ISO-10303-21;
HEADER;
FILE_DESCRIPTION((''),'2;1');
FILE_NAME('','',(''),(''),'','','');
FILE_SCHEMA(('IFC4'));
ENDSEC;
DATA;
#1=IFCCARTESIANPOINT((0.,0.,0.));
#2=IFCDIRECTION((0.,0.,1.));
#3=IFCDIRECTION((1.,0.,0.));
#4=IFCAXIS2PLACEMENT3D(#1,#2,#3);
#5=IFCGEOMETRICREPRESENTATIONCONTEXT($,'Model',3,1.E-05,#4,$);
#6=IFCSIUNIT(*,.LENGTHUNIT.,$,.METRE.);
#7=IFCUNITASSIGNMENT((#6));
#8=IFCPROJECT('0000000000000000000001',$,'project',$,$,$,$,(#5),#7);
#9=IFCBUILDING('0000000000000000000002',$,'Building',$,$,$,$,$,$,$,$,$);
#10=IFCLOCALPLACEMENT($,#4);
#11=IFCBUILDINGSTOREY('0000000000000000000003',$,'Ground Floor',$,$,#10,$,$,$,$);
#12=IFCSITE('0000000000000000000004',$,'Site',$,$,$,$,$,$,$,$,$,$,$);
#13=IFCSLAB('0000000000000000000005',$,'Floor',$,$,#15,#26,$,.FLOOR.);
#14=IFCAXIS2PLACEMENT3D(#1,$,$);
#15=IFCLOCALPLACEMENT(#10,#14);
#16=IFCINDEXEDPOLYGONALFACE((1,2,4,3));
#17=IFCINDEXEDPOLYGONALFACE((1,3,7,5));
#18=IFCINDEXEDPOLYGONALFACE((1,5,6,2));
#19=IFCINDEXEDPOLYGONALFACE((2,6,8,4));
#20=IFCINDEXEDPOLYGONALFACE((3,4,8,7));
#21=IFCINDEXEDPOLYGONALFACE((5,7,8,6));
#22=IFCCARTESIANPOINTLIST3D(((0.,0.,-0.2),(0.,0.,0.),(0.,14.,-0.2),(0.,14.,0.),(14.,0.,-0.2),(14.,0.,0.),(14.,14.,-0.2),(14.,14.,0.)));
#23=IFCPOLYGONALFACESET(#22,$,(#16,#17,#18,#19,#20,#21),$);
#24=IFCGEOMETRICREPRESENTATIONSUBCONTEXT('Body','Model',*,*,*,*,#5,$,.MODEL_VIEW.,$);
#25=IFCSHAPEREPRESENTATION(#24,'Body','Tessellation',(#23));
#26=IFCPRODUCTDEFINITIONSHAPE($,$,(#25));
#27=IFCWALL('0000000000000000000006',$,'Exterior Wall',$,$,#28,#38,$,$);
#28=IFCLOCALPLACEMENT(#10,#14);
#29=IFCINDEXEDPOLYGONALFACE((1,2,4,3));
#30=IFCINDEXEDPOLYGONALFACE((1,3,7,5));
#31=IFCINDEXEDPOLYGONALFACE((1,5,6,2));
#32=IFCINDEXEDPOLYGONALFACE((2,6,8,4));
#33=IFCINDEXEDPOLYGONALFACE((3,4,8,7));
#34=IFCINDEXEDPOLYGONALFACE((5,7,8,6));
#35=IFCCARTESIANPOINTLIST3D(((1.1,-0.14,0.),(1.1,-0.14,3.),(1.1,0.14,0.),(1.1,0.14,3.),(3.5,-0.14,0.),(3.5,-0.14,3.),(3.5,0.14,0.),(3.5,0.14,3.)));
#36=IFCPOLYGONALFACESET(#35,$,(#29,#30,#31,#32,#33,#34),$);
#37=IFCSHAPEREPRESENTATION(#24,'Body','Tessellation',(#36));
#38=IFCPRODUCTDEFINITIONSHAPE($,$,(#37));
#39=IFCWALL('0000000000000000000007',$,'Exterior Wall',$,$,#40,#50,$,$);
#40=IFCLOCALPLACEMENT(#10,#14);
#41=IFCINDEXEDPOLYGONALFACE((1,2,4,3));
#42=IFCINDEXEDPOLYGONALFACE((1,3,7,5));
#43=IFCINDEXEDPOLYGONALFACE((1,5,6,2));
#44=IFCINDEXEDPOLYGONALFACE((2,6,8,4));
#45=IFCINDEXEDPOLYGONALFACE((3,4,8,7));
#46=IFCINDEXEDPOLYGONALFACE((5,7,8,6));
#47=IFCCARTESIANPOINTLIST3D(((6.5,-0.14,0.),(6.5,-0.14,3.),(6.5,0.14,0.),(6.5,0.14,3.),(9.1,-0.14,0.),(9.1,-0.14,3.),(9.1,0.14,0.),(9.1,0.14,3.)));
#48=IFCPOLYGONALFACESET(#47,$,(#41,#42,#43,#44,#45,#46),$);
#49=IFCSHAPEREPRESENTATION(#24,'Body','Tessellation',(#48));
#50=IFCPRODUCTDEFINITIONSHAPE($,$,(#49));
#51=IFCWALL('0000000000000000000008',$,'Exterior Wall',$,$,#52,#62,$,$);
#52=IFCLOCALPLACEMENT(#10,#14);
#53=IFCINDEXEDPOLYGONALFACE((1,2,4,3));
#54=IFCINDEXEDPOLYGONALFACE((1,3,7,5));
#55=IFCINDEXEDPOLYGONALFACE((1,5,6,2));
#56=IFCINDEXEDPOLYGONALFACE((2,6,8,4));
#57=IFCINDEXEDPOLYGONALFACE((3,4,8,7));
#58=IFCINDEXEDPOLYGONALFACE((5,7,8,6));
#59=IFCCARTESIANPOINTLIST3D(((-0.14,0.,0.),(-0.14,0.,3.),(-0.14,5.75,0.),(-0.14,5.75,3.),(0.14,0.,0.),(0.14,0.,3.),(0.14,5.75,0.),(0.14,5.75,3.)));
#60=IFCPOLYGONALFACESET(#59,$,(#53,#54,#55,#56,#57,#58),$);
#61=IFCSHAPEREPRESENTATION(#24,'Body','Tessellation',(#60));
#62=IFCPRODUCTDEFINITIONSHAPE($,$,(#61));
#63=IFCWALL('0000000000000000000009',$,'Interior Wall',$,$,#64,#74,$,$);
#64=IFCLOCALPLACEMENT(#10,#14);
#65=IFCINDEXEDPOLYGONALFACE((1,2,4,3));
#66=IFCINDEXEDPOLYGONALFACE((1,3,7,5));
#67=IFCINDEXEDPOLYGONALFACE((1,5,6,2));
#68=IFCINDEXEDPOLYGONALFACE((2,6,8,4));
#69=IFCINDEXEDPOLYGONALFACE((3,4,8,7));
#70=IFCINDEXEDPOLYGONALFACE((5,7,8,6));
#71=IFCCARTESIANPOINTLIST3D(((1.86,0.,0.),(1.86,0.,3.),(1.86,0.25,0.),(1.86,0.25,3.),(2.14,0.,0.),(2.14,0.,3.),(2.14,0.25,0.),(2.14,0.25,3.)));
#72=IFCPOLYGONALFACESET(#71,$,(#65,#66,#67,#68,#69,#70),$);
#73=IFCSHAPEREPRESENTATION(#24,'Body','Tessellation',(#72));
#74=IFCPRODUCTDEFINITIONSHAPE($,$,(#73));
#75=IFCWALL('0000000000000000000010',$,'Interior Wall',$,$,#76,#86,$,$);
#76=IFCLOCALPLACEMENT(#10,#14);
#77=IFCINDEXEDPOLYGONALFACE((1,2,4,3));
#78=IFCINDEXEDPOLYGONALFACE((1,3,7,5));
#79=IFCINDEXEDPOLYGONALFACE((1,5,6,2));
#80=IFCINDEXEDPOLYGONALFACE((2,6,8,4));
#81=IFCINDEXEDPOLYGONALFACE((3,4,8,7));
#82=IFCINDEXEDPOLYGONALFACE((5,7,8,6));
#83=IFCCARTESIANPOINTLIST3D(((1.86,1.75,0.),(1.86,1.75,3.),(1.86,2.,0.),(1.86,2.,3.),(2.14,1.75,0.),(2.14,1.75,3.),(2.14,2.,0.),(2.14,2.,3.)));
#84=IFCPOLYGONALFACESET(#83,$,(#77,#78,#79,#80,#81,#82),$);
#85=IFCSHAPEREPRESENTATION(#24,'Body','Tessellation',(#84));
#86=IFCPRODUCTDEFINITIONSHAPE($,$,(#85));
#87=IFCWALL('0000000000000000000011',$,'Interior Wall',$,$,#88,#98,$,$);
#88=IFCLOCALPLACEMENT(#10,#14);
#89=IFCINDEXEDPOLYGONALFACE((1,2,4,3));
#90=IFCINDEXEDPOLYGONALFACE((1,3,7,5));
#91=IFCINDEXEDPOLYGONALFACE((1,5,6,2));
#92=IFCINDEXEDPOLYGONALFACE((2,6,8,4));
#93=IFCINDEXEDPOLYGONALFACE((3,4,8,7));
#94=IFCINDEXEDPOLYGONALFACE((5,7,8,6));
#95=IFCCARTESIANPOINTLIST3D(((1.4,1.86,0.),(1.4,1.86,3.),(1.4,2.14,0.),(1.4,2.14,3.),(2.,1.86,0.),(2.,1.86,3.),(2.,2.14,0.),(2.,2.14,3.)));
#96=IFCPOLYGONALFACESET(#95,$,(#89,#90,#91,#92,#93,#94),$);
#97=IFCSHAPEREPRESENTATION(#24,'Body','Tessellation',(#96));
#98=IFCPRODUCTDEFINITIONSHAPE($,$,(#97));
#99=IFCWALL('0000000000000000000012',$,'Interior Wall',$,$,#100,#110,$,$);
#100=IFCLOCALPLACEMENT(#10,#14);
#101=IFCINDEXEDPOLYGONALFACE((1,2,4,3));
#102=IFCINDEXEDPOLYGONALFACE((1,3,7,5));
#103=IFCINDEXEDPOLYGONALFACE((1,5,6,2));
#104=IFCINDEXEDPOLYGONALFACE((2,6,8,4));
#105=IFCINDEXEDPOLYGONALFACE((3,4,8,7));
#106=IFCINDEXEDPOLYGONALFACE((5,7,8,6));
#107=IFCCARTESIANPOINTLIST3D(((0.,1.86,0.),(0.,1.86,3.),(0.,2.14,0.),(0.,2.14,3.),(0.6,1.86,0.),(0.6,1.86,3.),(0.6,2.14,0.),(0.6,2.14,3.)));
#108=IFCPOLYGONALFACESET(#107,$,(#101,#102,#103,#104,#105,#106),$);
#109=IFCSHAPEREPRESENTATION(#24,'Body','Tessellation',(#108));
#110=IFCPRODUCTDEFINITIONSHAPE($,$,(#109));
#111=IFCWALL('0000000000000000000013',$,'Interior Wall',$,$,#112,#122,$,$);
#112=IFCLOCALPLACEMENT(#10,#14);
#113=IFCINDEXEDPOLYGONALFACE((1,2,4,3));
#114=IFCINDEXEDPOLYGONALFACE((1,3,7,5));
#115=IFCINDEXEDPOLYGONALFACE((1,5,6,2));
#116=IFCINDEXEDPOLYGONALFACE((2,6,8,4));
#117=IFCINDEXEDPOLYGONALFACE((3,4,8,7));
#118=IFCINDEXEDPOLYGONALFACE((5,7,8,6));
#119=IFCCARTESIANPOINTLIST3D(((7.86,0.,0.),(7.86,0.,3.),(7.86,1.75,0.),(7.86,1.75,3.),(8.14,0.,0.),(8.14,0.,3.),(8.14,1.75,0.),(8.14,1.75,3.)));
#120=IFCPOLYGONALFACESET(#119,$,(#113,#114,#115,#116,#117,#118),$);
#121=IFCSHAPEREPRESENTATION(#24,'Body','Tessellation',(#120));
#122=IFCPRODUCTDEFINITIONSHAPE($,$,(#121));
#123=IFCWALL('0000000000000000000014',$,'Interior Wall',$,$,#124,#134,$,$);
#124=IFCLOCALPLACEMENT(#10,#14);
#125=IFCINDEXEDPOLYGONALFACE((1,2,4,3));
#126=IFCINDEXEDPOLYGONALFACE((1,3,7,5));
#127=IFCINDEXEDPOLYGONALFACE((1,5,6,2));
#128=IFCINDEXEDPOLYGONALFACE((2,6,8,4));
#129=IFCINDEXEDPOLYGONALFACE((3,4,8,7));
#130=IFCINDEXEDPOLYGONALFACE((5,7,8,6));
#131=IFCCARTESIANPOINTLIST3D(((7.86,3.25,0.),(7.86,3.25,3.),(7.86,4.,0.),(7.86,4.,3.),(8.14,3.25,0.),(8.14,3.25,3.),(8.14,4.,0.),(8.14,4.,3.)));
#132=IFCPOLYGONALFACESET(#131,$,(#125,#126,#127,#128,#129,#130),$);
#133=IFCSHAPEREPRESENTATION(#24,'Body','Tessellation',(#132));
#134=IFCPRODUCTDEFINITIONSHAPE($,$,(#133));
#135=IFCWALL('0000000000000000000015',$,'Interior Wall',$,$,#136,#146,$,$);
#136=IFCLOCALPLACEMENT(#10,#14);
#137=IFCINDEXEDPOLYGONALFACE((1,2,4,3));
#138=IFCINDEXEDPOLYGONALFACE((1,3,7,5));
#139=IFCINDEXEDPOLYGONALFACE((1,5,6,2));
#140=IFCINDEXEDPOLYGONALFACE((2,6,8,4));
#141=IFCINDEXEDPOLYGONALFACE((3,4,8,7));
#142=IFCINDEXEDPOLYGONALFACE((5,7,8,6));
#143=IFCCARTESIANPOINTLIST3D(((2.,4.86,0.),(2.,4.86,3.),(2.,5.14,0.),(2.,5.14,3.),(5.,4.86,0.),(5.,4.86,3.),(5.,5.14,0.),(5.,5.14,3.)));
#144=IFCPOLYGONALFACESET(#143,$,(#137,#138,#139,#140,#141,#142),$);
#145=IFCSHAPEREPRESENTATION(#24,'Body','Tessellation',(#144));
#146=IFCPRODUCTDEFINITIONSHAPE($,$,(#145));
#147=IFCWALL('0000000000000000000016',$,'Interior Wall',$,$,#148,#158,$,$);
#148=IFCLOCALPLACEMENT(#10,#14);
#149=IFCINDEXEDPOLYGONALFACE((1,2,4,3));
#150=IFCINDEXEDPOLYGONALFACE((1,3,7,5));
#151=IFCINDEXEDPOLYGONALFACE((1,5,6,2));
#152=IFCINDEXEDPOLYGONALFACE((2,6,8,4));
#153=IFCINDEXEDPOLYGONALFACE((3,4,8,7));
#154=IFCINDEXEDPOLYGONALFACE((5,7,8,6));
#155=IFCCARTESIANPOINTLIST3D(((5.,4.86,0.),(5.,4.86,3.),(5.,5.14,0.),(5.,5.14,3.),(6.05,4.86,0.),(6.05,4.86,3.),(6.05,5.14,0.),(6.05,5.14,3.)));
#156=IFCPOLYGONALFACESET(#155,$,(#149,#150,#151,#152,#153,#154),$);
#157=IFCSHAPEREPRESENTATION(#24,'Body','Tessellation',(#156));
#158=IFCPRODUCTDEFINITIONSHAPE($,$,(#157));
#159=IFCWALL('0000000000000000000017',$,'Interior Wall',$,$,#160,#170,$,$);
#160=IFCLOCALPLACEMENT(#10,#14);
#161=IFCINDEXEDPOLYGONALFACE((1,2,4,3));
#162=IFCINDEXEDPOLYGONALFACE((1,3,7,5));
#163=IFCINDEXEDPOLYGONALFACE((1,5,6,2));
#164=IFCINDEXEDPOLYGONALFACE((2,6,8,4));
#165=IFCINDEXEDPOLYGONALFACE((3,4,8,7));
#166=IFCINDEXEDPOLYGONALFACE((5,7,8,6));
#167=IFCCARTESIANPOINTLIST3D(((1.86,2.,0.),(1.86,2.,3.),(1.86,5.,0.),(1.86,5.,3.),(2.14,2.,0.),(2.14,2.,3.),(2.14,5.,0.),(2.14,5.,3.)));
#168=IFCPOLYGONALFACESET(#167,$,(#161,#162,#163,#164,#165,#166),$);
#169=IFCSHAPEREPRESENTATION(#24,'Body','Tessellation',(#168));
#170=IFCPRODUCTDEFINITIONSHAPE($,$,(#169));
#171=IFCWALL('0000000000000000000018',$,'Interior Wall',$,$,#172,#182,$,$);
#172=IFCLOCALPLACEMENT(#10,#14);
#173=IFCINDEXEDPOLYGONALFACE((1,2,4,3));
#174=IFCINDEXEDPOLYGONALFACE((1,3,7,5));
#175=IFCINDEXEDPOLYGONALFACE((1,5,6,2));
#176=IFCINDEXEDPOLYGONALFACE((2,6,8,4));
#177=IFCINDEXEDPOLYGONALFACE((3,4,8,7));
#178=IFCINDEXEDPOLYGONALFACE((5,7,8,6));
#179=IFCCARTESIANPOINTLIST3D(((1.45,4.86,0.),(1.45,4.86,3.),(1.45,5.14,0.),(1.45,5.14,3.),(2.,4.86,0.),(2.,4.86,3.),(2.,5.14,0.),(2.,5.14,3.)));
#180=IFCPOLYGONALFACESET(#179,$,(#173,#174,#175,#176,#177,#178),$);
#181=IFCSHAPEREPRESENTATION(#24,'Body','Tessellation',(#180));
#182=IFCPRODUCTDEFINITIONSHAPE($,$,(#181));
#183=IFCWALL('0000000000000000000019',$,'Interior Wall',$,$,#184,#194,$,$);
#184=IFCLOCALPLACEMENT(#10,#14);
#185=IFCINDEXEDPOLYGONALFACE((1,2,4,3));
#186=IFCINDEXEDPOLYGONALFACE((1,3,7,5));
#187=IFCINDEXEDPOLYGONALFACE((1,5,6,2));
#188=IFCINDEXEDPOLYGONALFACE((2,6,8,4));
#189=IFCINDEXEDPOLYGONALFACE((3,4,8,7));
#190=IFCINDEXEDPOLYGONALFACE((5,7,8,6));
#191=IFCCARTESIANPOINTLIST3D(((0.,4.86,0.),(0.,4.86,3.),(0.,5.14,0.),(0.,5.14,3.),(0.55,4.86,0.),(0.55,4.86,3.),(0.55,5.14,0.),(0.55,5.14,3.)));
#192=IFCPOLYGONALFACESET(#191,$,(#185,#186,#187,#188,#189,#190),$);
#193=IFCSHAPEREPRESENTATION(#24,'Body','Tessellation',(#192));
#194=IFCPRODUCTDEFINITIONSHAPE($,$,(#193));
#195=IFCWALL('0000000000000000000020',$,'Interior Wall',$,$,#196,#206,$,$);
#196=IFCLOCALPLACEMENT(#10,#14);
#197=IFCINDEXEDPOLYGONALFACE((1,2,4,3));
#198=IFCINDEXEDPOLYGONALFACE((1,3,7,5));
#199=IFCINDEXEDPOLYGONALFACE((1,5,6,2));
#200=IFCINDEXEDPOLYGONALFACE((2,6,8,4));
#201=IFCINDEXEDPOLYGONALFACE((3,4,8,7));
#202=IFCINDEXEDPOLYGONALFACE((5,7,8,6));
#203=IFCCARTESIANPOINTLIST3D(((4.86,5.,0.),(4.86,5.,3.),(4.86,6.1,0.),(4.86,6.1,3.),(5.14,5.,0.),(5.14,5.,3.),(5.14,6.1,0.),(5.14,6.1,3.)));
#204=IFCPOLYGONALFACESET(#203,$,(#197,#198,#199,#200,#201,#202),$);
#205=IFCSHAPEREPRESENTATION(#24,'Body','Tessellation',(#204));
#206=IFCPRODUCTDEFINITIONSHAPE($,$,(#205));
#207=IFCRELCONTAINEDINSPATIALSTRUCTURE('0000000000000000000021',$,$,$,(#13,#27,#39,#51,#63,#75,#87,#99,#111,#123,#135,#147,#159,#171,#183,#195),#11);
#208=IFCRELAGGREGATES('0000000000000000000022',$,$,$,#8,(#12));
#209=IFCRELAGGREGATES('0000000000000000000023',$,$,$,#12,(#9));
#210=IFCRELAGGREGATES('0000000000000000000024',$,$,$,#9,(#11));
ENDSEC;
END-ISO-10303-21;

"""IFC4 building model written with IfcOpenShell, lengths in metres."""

from ifc_helpers import new_model, si_unit, frame, origin_with_axes, place, context, subcontext, project, spatial, indexed_curve, outline, extrude, element, save


model = new_model("IFC4")

# Units and contexts
model_context = context("Model", 3, precision=1e-05, world=origin_with_axes())
body_context = subcontext(model_context, "Body", "Model", "MODEL_VIEW")
ifc_project = project(units=[si_unit("LENGTHUNIT", "METRE")], contexts=[model_context])

# Site, building, storey
site = spatial("IfcSite", under=ifc_project, Name="Site")
building = spatial("IfcBuilding", under=site, Name="Building")
storey_placement = place(None, origin_with_axes())
storey = spatial("IfcBuildingStorey", under=building, at=storey_placement, Name="Ground Floor")

# Slab
slab_placement = place(storey_placement, frame((0.0, 0.0, -0.2), z_axis=(0.0, 0.0, 1.0), x_axis=(1.0, 0.0, 0.0)))
element("IfcSlab", 1, at=slab_placement, inside=storey, Name="Floor", PredefinedType="FLOOR", context=body_context, shape_type="SweptSolid", body=[
    extrude(outline(indexed_curve([(0.0, 0.0), (14.0, 0.0), (14.0, 14.0), (0.0, 14.0)])), None, (0.0, 0.0, 1.0), 0.2),
])

# Walls
wall_1_placement = place(storey_placement, frame((1.1, 0.0, 0.0), z_axis=(0.0, 0.0, 1.0), x_axis=(1.0, 0.0, 0.0)))
element("IfcWall", 2, at=wall_1_placement, inside=storey, Name="Exterior Wall", context=body_context, shape_type="SweptSolid", body=[
    extrude(outline(indexed_curve([(0.0, 0.0), (0.0, 0.28), (2.4, 0.28), (2.4, 0.0), (0.0, 0.0)], self_intersect=False)), frame((0.0, -0.14, 0.0), z_axis=(0.0, 0.0, 1.0), x_axis=(1.0, 0.0, 0.0)), (0.0, 0.0, 1.0), 3.0),
])
wall_2_placement = place(storey_placement, frame((6.5, 0.0, 0.0), z_axis=(0.0, 0.0, 1.0), x_axis=(1.0, 0.0, 0.0)))
element("IfcWall", 3, at=wall_2_placement, inside=storey, Name="Exterior Wall", context=body_context, shape_type="SweptSolid", body=[
    extrude(outline(indexed_curve([(0.0, 0.0), (0.0, 0.28), (2.6, 0.28), (2.6, 0.0), (0.0, 0.0)], self_intersect=False)), frame((0.0, -0.14, 0.0), z_axis=(0.0, 0.0, 1.0), x_axis=(1.0, 0.0, 0.0)), (0.0, 0.0, 1.0), 3.0),
])
wall_3_placement = place(storey_placement, frame((0.0, 5.75, 0.0), z_axis=(0.0, 0.0, 1.0), x_axis=(0.0, -1.0, 0.0)))
element("IfcWall", 4, at=wall_3_placement, inside=storey, Name="Exterior Wall", context=body_context, shape_type="SweptSolid", body=[
    extrude(outline(indexed_curve([(0.0, 0.0), (0.0, 0.28), (5.75, 0.28), (5.75, 0.0), (0.0, 0.0)], self_intersect=False)), frame((0.0, -0.14, 0.0), z_axis=(0.0, 0.0, 1.0), x_axis=(1.0, 0.0, 0.0)), (0.0, 0.0, 1.0), 3.0),
])
for number, where, z_axis, x_axis, name in (
    (5, (2.0, 0.0, 0.0), (0.0, 0.0, 1.0), (0.0, 1.0, 0.0), "Interior Wall"),
    (6, (2.0, 1.75, 0.0), (0.0, 0.0, 1.0), (0.0, 1.0, 0.0), "Interior Wall"),
):
    element("IfcWall", number, at=place(storey_placement, frame(where, z_axis=z_axis, x_axis=x_axis)), inside=storey, Name=name, context=body_context, shape_type="SweptSolid", body=[
        extrude(outline(indexed_curve([(0.0, 0.0), (0.0, 0.28), (0.25, 0.28), (0.25, 0.0), (0.0, 0.0)], self_intersect=False)), frame((0.0, -0.14, 0.0), z_axis=(0.0, 0.0, 1.0), x_axis=(1.0, 0.0, 0.0)), (0.0, 0.0, 1.0), 3.0),
    ])
for number, where, z_axis, x_axis, name in (
    (7, (2.0, 2.0, 0.0), (0.0, 0.0, 1.0), (-1.0, 0.0, 0.0), "Interior Wall"),
    (8, (0.6, 2.0, 0.0), (0.0, 0.0, 1.0), (-1.0, 0.0, 0.0), "Interior Wall"),
):
    element("IfcWall", number, at=place(storey_placement, frame(where, z_axis=z_axis, x_axis=x_axis)), inside=storey, Name=name, context=body_context, shape_type="SweptSolid", body=[
        extrude(outline(indexed_curve([(0.0, 0.0), (0.0, 0.28), (0.6, 0.28), (0.6, 0.0), (0.0, 0.0)], self_intersect=False)), frame((0.0, -0.14, 0.0), z_axis=(0.0, 0.0, 1.0), x_axis=(1.0, 0.0, 0.0)), (0.0, 0.0, 1.0), 3.0),
    ])
wall_4_placement = place(storey_placement, frame((8.0, 0.0, 0.0), z_axis=(0.0, 0.0, 1.0), x_axis=(0.0, 1.0, 0.0)))
element("IfcWall", 9, at=wall_4_placement, inside=storey, Name="Interior Wall", context=body_context, shape_type="SweptSolid", body=[
    extrude(outline(indexed_curve([(0.0, 0.0), (0.0, 0.28), (1.75, 0.28), (1.75, 0.0), (0.0, 0.0)], self_intersect=False)), frame((0.0, -0.14, 0.0), z_axis=(0.0, 0.0, 1.0), x_axis=(1.0, 0.0, 0.0)), (0.0, 0.0, 1.0), 3.0),
])
wall_5_placement = place(storey_placement, frame((8.0, 3.25, 0.0), z_axis=(0.0, 0.0, 1.0), x_axis=(0.0, 1.0, 0.0)))
element("IfcWall", 10, at=wall_5_placement, inside=storey, Name="Interior Wall", context=body_context, shape_type="SweptSolid", body=[
    extrude(outline(indexed_curve([(0.0, 0.0), (0.0, 0.28), (0.75, 0.28), (0.75, 0.0), (0.0, 0.0)], self_intersect=False)), frame((0.0, -0.14, 0.0), z_axis=(0.0, 0.0, 1.0), x_axis=(1.0, 0.0, 0.0)), (0.0, 0.0, 1.0), 3.0),
])
wall_6_placement = place(storey_placement, frame((5.0, 5.0, 0.0), z_axis=(0.0, 0.0, 1.0), x_axis=(-1.0, 0.0, 0.0)))
element("IfcWall", 11, at=wall_6_placement, inside=storey, Name="Interior Wall", context=body_context, shape_type="SweptSolid", body=[
    extrude(outline(indexed_curve([(0.0, 0.0), (0.0, 0.28), (3.0, 0.28), (3.0, 0.0), (0.0, 0.0)], self_intersect=False)), frame((0.0, -0.14, 0.0), z_axis=(0.0, 0.0, 1.0), x_axis=(1.0, 0.0, 0.0)), (0.0, 0.0, 1.0), 3.0),
])
wall_7_placement = place(storey_placement, frame((6.05, 5.0, 0.0), z_axis=(0.0, 0.0, 1.0), x_axis=(-1.0, 0.0, 0.0)))
element("IfcWall", 12, at=wall_7_placement, inside=storey, Name="Interior Wall", context=body_context, shape_type="SweptSolid", body=[
    extrude(outline(indexed_curve([(0.0, 0.0), (0.0, 0.28), (1.05, 0.28), (1.05, 0.0), (0.0, 0.0)], self_intersect=False)), frame((0.0, -0.14, 0.0), z_axis=(0.0, 0.0, 1.0), x_axis=(1.0, 0.0, 0.0)), (0.0, 0.0, 1.0), 3.0),
])
wall_8_placement = place(storey_placement, frame((2.0, 5.0, 0.0), z_axis=(0.0, 0.0, 1.0), x_axis=(0.0, -1.0, 0.0)))
element("IfcWall", 13, at=wall_8_placement, inside=storey, Name="Interior Wall", context=body_context, shape_type="SweptSolid", body=[
    extrude(outline(indexed_curve([(0.0, 0.0), (0.0, 0.28), (3.0, 0.28), (3.0, 0.0), (0.0, 0.0)], self_intersect=False)), frame((0.0, -0.14, 0.0), z_axis=(0.0, 0.0, 1.0), x_axis=(1.0, 0.0, 0.0)), (0.0, 0.0, 1.0), 3.0),
])
for number, where, z_axis, x_axis, name in (
    (14, (2.0, 5.0, 0.0), (0.0, 0.0, 1.0), (-1.0, 0.0, 0.0), "Interior Wall"),
    (15, (0.55, 5.0, 0.0), (0.0, 0.0, 1.0), (-1.0, 0.0, 0.0), "Interior Wall"),
):
    element("IfcWall", number, at=place(storey_placement, frame(where, z_axis=z_axis, x_axis=x_axis)), inside=storey, Name=name, context=body_context, shape_type="SweptSolid", body=[
        extrude(outline(indexed_curve([(0.0, 0.0), (0.0, 0.28), (0.55, 0.28), (0.55, 0.0), (0.0, 0.0)], self_intersect=False)), frame((0.0, -0.14, 0.0), z_axis=(0.0, 0.0, 1.0), x_axis=(1.0, 0.0, 0.0)), (0.0, 0.0, 1.0), 3.0),
    ])
for number, where, z_axis, x_axis, name in (
    (16, (5.0, 5.0, 0.0), (0.0, 0.0, 1.0), (0.0, 1.0, 0.0), "Interior Wall"),
):
    element("IfcWall", number, at=place(storey_placement, frame(where, z_axis=z_axis, x_axis=x_axis)), inside=storey, Name=name, context=body_context, shape_type="SweptSolid", body=[
        extrude(outline(indexed_curve([(0.0, 0.0), (0.0, 0.28), (1.1, 0.28), (1.1, 0.0), (0.0, 0.0)], self_intersect=False)), frame((0.0, -0.14, 0.0), z_axis=(0.0, 0.0, 1.0), x_axis=(1.0, 0.0, 0.0)), (0.0, 0.0, 1.0), 3.0),
    ])

save(model, "model.ifc")
